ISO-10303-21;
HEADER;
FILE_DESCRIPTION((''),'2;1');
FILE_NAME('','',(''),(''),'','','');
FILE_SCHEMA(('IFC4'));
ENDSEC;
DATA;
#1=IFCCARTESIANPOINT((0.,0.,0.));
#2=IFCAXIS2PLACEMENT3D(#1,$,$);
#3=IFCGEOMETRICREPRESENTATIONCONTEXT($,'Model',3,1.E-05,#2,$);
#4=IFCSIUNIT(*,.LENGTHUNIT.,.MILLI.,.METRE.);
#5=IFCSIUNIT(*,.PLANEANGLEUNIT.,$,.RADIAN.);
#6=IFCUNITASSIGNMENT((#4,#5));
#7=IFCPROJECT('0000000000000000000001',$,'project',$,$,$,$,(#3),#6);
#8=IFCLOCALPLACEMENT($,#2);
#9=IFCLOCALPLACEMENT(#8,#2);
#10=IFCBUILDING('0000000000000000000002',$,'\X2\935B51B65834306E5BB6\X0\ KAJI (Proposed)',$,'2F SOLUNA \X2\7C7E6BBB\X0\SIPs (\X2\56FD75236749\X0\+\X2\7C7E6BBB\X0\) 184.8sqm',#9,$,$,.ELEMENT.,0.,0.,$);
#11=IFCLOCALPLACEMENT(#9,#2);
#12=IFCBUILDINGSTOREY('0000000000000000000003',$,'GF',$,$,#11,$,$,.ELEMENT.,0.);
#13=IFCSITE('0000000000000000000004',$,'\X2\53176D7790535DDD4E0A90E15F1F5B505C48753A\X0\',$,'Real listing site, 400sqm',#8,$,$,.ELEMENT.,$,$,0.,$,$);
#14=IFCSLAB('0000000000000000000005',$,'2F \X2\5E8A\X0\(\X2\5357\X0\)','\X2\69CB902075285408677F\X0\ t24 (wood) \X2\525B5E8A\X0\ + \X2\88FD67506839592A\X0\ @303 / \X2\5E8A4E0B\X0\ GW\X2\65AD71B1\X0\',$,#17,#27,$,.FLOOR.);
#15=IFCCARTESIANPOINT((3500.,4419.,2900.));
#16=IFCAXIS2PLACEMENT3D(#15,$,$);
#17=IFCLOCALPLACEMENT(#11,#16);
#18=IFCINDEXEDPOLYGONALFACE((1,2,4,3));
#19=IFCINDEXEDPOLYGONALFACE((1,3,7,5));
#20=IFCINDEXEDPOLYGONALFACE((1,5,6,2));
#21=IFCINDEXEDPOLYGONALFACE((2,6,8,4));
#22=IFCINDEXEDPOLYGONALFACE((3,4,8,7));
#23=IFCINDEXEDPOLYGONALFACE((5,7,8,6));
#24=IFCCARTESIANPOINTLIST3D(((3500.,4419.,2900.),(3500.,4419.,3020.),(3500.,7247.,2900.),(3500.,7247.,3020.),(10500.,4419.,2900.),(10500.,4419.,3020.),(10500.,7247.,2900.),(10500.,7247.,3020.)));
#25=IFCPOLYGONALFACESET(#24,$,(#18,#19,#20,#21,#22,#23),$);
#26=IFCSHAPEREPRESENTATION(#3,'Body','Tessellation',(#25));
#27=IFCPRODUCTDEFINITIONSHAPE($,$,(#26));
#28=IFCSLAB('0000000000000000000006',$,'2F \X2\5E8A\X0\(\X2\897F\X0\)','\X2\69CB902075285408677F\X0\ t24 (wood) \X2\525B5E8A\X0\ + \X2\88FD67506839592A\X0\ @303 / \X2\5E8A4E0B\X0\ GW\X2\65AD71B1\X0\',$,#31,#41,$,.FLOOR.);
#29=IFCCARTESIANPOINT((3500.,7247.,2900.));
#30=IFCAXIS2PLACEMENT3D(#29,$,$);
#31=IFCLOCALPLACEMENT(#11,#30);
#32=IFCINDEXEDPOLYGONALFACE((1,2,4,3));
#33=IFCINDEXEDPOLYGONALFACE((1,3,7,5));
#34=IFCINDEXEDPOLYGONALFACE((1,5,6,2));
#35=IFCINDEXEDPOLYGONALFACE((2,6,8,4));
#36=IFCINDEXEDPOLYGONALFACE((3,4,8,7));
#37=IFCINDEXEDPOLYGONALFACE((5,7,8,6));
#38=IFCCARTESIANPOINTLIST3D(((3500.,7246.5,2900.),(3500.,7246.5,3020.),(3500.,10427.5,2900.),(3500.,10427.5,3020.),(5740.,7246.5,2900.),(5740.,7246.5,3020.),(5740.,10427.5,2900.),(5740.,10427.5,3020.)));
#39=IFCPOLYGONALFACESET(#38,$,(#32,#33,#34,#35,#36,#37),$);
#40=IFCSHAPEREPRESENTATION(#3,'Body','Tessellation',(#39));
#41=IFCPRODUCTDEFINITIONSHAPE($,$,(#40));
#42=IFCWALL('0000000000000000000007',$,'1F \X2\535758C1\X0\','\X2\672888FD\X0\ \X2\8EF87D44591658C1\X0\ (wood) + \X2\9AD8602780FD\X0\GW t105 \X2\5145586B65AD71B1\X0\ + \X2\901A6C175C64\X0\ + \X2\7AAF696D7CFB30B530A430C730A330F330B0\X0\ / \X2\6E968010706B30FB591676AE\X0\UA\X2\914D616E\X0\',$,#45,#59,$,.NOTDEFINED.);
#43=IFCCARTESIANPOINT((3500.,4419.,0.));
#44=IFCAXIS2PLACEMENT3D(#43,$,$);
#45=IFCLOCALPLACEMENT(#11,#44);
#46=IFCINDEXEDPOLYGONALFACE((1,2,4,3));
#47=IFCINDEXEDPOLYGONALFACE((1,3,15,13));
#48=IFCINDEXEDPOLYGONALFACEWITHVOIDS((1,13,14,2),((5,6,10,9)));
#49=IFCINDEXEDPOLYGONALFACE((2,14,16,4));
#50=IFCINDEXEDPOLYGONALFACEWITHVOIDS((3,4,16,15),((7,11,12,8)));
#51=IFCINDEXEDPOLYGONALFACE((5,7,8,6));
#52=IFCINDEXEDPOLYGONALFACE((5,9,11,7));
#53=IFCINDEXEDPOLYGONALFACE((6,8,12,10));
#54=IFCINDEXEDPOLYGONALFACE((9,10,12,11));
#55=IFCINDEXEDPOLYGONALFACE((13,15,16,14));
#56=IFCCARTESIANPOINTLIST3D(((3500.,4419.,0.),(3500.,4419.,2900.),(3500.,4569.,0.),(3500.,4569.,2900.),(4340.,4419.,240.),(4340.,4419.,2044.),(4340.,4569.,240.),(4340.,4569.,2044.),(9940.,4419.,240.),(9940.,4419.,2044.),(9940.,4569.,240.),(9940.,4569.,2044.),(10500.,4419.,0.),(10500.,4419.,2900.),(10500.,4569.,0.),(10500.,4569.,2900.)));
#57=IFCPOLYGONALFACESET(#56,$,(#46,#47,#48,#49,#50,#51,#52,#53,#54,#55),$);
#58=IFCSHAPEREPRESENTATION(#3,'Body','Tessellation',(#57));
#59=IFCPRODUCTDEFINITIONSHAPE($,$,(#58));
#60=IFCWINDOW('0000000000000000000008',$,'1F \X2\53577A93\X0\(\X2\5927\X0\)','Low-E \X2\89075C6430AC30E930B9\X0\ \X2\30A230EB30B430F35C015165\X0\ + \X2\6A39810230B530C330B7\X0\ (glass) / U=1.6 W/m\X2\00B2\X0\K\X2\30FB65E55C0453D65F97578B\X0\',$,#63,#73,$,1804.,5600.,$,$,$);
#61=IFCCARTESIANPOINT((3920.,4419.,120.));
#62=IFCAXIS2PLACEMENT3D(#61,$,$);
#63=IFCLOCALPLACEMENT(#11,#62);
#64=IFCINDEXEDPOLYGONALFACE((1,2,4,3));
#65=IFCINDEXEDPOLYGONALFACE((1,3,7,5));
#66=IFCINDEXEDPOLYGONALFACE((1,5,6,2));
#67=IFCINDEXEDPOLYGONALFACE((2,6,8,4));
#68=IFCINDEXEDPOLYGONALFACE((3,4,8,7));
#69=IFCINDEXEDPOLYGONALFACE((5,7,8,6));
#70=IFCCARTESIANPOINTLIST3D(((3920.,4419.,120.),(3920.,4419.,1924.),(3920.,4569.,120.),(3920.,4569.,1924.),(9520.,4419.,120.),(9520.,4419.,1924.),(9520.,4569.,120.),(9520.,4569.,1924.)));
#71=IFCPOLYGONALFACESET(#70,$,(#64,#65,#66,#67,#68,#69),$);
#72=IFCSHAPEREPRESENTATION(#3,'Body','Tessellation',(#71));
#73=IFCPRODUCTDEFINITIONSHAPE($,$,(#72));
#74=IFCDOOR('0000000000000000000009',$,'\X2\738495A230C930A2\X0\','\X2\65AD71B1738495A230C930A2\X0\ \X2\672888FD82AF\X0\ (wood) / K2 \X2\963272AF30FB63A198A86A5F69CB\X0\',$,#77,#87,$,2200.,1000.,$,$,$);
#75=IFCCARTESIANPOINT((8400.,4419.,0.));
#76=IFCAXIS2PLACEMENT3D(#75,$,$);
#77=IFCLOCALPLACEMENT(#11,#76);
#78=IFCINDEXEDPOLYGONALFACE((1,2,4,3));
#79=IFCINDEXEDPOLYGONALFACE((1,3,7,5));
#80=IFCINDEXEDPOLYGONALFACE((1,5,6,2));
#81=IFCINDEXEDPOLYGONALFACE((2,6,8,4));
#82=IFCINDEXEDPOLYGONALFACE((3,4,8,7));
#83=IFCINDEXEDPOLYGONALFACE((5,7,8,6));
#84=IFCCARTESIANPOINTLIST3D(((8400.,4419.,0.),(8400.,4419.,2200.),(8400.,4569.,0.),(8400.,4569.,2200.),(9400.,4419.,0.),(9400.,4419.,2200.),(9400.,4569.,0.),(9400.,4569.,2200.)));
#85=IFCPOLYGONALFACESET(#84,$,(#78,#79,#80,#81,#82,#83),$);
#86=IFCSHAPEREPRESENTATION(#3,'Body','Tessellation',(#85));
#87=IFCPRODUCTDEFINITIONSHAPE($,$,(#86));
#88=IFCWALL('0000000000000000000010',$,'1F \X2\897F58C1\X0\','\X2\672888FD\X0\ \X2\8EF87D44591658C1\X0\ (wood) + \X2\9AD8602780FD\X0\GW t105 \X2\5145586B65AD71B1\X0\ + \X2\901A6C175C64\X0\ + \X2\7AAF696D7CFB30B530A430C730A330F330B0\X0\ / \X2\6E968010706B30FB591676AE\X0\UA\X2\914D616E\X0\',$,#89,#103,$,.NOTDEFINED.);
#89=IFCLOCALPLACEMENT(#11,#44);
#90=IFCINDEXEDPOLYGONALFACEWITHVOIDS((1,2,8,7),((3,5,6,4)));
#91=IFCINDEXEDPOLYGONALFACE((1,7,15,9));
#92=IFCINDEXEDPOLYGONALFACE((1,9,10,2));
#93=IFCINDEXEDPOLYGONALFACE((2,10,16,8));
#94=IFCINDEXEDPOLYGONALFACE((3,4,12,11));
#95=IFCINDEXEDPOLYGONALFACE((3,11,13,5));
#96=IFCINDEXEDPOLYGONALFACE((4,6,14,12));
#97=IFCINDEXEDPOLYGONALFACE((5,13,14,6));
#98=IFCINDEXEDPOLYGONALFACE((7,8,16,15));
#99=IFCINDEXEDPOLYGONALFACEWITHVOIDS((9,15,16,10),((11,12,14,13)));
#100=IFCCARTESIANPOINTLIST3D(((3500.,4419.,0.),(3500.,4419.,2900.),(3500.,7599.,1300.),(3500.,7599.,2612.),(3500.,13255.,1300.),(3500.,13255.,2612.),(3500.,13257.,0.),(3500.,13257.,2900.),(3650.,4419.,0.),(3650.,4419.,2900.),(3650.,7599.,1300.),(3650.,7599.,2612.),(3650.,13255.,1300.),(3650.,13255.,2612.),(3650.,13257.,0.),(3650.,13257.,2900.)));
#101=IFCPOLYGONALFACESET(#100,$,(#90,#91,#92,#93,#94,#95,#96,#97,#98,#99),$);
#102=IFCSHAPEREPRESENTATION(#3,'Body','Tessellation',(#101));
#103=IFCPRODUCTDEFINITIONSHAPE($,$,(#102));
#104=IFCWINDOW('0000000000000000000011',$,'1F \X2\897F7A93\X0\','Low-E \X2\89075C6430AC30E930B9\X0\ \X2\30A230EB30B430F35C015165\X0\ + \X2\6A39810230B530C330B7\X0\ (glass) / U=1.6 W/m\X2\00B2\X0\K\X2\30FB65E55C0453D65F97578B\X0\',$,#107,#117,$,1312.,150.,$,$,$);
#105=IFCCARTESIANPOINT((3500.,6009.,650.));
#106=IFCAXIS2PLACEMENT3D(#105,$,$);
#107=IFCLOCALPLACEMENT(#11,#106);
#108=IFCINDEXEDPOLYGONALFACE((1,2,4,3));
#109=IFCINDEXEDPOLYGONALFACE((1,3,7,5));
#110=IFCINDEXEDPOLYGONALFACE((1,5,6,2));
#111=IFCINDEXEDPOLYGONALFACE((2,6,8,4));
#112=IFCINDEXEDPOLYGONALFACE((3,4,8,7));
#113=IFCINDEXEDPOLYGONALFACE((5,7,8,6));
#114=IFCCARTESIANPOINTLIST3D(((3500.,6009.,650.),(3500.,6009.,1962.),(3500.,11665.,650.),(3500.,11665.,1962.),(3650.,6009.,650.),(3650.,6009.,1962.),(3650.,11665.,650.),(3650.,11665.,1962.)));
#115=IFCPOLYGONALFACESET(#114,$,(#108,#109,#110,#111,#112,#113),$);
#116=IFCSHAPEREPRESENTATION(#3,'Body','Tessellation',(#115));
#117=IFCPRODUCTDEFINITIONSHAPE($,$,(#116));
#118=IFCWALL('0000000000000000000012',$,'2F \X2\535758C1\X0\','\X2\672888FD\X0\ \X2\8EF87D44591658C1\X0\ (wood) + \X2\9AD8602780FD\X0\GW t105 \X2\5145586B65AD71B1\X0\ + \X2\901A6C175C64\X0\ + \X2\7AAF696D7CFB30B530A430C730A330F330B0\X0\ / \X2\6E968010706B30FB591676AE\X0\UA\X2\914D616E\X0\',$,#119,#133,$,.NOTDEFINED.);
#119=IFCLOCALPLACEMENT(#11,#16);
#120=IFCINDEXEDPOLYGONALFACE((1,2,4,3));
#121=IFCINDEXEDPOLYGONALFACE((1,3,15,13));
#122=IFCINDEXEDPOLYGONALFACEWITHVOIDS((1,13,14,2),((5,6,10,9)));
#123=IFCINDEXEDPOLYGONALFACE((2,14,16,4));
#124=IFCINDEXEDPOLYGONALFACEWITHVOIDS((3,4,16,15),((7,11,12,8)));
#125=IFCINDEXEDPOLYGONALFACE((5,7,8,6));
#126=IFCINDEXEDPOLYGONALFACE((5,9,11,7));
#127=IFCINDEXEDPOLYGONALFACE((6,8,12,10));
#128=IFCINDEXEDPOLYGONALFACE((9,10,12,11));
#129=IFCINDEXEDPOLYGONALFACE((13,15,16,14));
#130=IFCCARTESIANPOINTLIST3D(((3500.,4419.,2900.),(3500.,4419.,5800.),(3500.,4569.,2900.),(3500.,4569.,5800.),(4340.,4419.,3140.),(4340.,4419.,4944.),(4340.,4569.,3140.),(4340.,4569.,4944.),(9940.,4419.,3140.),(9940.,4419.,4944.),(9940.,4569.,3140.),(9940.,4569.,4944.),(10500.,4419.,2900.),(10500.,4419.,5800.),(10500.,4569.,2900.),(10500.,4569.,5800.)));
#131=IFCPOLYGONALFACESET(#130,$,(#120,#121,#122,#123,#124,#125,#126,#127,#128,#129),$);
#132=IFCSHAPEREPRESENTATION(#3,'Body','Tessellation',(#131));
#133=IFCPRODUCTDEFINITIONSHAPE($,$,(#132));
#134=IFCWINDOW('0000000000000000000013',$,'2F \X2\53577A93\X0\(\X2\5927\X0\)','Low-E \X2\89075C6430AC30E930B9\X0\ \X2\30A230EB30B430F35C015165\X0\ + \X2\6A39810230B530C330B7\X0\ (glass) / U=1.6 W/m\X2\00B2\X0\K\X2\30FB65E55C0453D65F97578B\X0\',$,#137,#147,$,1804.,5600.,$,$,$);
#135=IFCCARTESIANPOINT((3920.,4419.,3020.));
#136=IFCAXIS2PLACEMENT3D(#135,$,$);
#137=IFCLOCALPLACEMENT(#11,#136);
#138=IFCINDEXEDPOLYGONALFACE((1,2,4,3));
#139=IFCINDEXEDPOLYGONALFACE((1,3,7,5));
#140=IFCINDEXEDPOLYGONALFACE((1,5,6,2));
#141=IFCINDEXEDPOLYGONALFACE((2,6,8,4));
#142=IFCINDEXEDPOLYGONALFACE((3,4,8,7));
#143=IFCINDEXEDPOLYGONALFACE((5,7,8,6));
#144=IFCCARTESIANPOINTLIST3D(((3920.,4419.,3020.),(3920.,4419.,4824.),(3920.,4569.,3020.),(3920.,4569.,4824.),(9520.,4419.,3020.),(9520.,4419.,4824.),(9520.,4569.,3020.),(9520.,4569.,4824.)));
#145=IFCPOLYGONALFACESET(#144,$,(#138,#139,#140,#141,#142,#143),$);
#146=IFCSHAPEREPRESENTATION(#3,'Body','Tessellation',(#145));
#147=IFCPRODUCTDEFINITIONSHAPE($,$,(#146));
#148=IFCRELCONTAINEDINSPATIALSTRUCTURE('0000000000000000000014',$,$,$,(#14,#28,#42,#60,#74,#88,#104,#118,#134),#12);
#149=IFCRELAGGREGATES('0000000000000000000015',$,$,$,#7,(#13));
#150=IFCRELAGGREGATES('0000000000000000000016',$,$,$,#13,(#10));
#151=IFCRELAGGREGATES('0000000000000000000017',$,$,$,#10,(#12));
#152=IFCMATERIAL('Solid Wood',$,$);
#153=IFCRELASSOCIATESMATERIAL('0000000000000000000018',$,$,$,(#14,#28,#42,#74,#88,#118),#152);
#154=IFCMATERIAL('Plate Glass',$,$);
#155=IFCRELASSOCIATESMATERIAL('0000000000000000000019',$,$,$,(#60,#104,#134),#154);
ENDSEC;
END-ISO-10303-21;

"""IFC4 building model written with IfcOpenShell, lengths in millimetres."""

from ifc_helpers import new_model, si_unit, frame, frame_2d, origin, place, context, project, spatial, rectangle, extrude, material, element, fill, save


model = new_model("IFC4")

# Units and contexts
model_context = context("Model", 3, precision=1e-05, world=origin())
ifc_project = project(units=[si_unit("LENGTHUNIT", "METRE", prefix="MILLI"), si_unit("PLANEANGLEUNIT", "RADIAN")], contexts=[model_context])

# Site, building, storey
site_placement = place(None, origin())
site = spatial("IfcSite", under=ifc_project, at=site_placement, Name="北海道川上郡弟子屈町", ObjectType="Real listing site, 400sqm", CompositionType="ELEMENT", RefElevation=0.0)
building_placement = place(site_placement, origin())
building = spatial("IfcBuilding", under=site, at=building_placement, Name="鍛冶場の家 KAJI (Proposed)", ObjectType="2F SOLUNA 籾殻SIPs (国産杉+籾殻) 184.8sqm", CompositionType="ELEMENT", ElevationOfRefHeight=0.0, ElevationOfTerrain=0.0)
storey_placement = place(building_placement, origin())
storey = spatial("IfcBuildingStorey", under=building, at=storey_placement, Name="GF", CompositionType="ELEMENT", Elevation=0.0)

# Slabs
ifc_material_1 = material(Name="Solid Wood")
slab_1_placement = place(storey_placement, frame((3500.0, 4419.0, 2900.0)))
element("IfcSlab", 1, at=slab_1_placement, inside=storey, material=ifc_material_1, Name="2F 床(南)", Description="構造用合板 t24 (wood) 剛床 + 製材根太 @303 / 床下 GW断熱", PredefinedType="FLOOR", context=model_context, shape_type="SweptSolid", body=[
    extrude(rectangle(XDim=7000.0, YDim=2828.0, at=frame_2d((3500.0, 1414.0))), frame((3500.0, 4419.0, 2900.0)), (0.0, 0.0, 1.0), 120.0),
])
slab_2_placement = place(storey_placement, frame((3500.0, 7247.0, 2900.0)))
element("IfcSlab", 2, at=slab_2_placement, inside=storey, material=ifc_material_1, Name="2F 床(西)", Description="構造用合板 t24 (wood) 剛床 + 製材根太 @303 / 床下 GW断熱", PredefinedType="FLOOR", context=model_context, shape_type="SweptSolid", body=[
    extrude(rectangle(XDim=2240.0, YDim=3181.0, at=frame_2d((1120.0, 1590.0))), frame((3500.0, 7247.0, 2900.0)), (0.0, 0.0, 1.0), 120.0),
])

# Wall, openings, window, door
wall_1_placement = place(storey_placement, frame((3500.0, 4419.0, 0.0)))
wall_1 = element("IfcWall", 3, at=wall_1_placement, inside=storey, material=ifc_material_1, Name="1F 南壁", Description="木製 軸組外壁 (wood) + 高性能GW t105 充填断熱 + 通気層 + 窯業系サイディング / 準耐火・外皮UA配慮", PredefinedType="NOTDEFINED", context=model_context, shape_type="SweptSolid", body=[
    extrude(rectangle(XDim=7000.0, YDim=150.0, at=frame_2d((3500.0, 75.0))), frame((3500.0, 4419.0, 0.0)), (0.0, 0.0, 1.0), 2900.0),
])
opening_1_placement = place(storey_placement, frame((3920.0, 4419.0, 120.0)))
opening_1 = element("IfcOpeningElement", 4, at=opening_1_placement, cuts=wall_1, PredefinedType="NOTDEFINED", context=model_context, shape_type="SweptSolid", body=[
    extrude(rectangle(XDim=5600.0, YDim=150.0, at=frame_2d((2800.0, 75.0))), frame((3920.0, 4419.0, 120.0)), (0.0, 0.0, 1.0), 1804.0),
])
opening_2_placement = place(storey_placement, frame((8400.0, 4419.0, 0.0)))
opening_2 = element("IfcOpeningElement", 5, at=opening_2_placement, cuts=wall_1, PredefinedType="NOTDEFINED", context=model_context, shape_type="SweptSolid", body=[
    extrude(rectangle(XDim=1000.0, YDim=150.0, at=frame_2d((500.0, 75.0))), frame((8400.0, 4419.0, 0.0)), (0.0, 0.0, 1.0), 2200.0),
])
ifc_material_2 = material(Name="Plate Glass")
window_1_placement = place(storey_placement, frame((3920.0, 4419.0, 120.0)))
window_1 = element("IfcWindow", 6, at=window_1_placement, inside=storey, material=ifc_material_2, Name="1F 南窓(大)", Description="Low-E 複層ガラス アルゴン封入 + 樹脂サッシ (glass) / U=1.6 W/m²K・日射取得型", OverallHeight=1804.0, OverallWidth=5600.0, context=model_context, shape_type="SweptSolid", body=[
    extrude(rectangle(XDim=5600.0, YDim=150.0, at=frame_2d((2800.0, 75.0))), frame((3920.0, 4419.0, 120.0)), (0.0, 0.0, 1.0), 1804.0),
])
fill(opening_1, window_1)
door_placement = place(storey_placement, frame((8400.0, 4419.0, 0.0)))
door = element("IfcDoor", 7, at=door_placement, inside=storey, material=ifc_material_1, Name="玄関ドア", Description="断熱玄関ドア 木製芯 (wood) / K2 防犯・採風機構", OverallHeight=2200.0, OverallWidth=1000.0, context=model_context, shape_type="SweptSolid", body=[
    extrude(rectangle(XDim=1000.0, YDim=150.0, at=frame_2d((500.0, 75.0))), frame((8400.0, 4419.0, 0.0)), (0.0, 0.0, 1.0), 2200.0),
])
fill(opening_2, door)

# Walls, openings, windows
wall_2_placement = place(storey_placement, frame((3500.0, 4419.0, 0.0)))
wall_2 = element("IfcWall", 8, at=wall_2_placement, inside=storey, material=ifc_material_1, Name="1F 西壁", Description="木製 軸組外壁 (wood) + 高性能GW t105 充填断熱 + 通気層 + 窯業系サイディング / 準耐火・外皮UA配慮", PredefinedType="NOTDEFINED", context=model_context, shape_type="SweptSolid", body=[
    extrude(rectangle(XDim=150.0, YDim=8838.0, at=frame_2d((75.0, 4419.0))), frame((3500.0, 4419.0, 0.0)), (0.0, 0.0, 1.0), 2900.0),
])
opening_3_placement = place(storey_placement, frame((3500.0, 6009.0, 650.0)))
opening_3 = element("IfcOpeningElement", 9, at=opening_3_placement, cuts=wall_2, PredefinedType="NOTDEFINED", context=model_context, shape_type="SweptSolid", body=[
    extrude(rectangle(XDim=150.0, YDim=5656.0, at=frame_2d((75.0, 2828.0))), frame((3500.0, 6009.0, 650.0)), (0.0, 0.0, 1.0), 1312.0),
])
window_2_placement = place(storey_placement, frame((3500.0, 6009.0, 650.0)))
window_2 = element("IfcWindow", 10, at=window_2_placement, inside=storey, material=ifc_material_2, Name="1F 西窓", Description="Low-E 複層ガラス アルゴン封入 + 樹脂サッシ (glass) / U=1.6 W/m²K・日射取得型", OverallHeight=1312.0, OverallWidth=150.0, context=model_context, shape_type="SweptSolid", body=[
    extrude(rectangle(XDim=150.0, YDim=5656.0, at=frame_2d((75.0, 2828.0))), frame((3500.0, 6009.0, 650.0)), (0.0, 0.0, 1.0), 1312.0),
])
fill(opening_3, window_2)
wall_3_placement = place(storey_placement, frame((3500.0, 4419.0, 2900.0)))
wall_3 = element("IfcWall", 11, at=wall_3_placement, inside=storey, material=ifc_material_1, Name="2F 南壁", Description="木製 軸組外壁 (wood) + 高性能GW t105 充填断熱 + 通気層 + 窯業系サイディング / 準耐火・外皮UA配慮", PredefinedType="NOTDEFINED", context=model_context, shape_type="SweptSolid", body=[
    extrude(rectangle(XDim=7000.0, YDim=150.0, at=frame_2d((3500.0, 75.0))), frame((3500.0, 4419.0, 2900.0)), (0.0, 0.0, 1.0), 2900.0),
])
opening_4_placement = place(storey_placement, frame((3920.0, 4419.0, 3020.0)))
opening_4 = element("IfcOpeningElement", 12, at=opening_4_placement, cuts=wall_3, PredefinedType="NOTDEFINED", context=model_context, shape_type="SweptSolid", body=[
    extrude(rectangle(XDim=5600.0, YDim=150.0, at=frame_2d((2800.0, 75.0))), frame((3920.0, 4419.0, 3020.0)), (0.0, 0.0, 1.0), 1804.0),
])
window_3_placement = place(storey_placement, frame((3920.0, 4419.0, 3020.0)))
window_3 = element("IfcWindow", 13, at=window_3_placement, inside=storey, material=ifc_material_2, Name="2F 南窓(大)", Description="Low-E 複層ガラス アルゴン封入 + 樹脂サッシ (glass) / U=1.6 W/m²K・日射取得型", OverallHeight=1804.0, OverallWidth=5600.0, context=model_context, shape_type="SweptSolid", body=[
    extrude(rectangle(XDim=5600.0, YDim=150.0, at=frame_2d((2800.0, 75.0))), frame((3920.0, 4419.0, 3020.0)), (0.0, 0.0, 1.0), 1804.0),
])
fill(opening_4, window_3)

save(model, "model.ifc")
